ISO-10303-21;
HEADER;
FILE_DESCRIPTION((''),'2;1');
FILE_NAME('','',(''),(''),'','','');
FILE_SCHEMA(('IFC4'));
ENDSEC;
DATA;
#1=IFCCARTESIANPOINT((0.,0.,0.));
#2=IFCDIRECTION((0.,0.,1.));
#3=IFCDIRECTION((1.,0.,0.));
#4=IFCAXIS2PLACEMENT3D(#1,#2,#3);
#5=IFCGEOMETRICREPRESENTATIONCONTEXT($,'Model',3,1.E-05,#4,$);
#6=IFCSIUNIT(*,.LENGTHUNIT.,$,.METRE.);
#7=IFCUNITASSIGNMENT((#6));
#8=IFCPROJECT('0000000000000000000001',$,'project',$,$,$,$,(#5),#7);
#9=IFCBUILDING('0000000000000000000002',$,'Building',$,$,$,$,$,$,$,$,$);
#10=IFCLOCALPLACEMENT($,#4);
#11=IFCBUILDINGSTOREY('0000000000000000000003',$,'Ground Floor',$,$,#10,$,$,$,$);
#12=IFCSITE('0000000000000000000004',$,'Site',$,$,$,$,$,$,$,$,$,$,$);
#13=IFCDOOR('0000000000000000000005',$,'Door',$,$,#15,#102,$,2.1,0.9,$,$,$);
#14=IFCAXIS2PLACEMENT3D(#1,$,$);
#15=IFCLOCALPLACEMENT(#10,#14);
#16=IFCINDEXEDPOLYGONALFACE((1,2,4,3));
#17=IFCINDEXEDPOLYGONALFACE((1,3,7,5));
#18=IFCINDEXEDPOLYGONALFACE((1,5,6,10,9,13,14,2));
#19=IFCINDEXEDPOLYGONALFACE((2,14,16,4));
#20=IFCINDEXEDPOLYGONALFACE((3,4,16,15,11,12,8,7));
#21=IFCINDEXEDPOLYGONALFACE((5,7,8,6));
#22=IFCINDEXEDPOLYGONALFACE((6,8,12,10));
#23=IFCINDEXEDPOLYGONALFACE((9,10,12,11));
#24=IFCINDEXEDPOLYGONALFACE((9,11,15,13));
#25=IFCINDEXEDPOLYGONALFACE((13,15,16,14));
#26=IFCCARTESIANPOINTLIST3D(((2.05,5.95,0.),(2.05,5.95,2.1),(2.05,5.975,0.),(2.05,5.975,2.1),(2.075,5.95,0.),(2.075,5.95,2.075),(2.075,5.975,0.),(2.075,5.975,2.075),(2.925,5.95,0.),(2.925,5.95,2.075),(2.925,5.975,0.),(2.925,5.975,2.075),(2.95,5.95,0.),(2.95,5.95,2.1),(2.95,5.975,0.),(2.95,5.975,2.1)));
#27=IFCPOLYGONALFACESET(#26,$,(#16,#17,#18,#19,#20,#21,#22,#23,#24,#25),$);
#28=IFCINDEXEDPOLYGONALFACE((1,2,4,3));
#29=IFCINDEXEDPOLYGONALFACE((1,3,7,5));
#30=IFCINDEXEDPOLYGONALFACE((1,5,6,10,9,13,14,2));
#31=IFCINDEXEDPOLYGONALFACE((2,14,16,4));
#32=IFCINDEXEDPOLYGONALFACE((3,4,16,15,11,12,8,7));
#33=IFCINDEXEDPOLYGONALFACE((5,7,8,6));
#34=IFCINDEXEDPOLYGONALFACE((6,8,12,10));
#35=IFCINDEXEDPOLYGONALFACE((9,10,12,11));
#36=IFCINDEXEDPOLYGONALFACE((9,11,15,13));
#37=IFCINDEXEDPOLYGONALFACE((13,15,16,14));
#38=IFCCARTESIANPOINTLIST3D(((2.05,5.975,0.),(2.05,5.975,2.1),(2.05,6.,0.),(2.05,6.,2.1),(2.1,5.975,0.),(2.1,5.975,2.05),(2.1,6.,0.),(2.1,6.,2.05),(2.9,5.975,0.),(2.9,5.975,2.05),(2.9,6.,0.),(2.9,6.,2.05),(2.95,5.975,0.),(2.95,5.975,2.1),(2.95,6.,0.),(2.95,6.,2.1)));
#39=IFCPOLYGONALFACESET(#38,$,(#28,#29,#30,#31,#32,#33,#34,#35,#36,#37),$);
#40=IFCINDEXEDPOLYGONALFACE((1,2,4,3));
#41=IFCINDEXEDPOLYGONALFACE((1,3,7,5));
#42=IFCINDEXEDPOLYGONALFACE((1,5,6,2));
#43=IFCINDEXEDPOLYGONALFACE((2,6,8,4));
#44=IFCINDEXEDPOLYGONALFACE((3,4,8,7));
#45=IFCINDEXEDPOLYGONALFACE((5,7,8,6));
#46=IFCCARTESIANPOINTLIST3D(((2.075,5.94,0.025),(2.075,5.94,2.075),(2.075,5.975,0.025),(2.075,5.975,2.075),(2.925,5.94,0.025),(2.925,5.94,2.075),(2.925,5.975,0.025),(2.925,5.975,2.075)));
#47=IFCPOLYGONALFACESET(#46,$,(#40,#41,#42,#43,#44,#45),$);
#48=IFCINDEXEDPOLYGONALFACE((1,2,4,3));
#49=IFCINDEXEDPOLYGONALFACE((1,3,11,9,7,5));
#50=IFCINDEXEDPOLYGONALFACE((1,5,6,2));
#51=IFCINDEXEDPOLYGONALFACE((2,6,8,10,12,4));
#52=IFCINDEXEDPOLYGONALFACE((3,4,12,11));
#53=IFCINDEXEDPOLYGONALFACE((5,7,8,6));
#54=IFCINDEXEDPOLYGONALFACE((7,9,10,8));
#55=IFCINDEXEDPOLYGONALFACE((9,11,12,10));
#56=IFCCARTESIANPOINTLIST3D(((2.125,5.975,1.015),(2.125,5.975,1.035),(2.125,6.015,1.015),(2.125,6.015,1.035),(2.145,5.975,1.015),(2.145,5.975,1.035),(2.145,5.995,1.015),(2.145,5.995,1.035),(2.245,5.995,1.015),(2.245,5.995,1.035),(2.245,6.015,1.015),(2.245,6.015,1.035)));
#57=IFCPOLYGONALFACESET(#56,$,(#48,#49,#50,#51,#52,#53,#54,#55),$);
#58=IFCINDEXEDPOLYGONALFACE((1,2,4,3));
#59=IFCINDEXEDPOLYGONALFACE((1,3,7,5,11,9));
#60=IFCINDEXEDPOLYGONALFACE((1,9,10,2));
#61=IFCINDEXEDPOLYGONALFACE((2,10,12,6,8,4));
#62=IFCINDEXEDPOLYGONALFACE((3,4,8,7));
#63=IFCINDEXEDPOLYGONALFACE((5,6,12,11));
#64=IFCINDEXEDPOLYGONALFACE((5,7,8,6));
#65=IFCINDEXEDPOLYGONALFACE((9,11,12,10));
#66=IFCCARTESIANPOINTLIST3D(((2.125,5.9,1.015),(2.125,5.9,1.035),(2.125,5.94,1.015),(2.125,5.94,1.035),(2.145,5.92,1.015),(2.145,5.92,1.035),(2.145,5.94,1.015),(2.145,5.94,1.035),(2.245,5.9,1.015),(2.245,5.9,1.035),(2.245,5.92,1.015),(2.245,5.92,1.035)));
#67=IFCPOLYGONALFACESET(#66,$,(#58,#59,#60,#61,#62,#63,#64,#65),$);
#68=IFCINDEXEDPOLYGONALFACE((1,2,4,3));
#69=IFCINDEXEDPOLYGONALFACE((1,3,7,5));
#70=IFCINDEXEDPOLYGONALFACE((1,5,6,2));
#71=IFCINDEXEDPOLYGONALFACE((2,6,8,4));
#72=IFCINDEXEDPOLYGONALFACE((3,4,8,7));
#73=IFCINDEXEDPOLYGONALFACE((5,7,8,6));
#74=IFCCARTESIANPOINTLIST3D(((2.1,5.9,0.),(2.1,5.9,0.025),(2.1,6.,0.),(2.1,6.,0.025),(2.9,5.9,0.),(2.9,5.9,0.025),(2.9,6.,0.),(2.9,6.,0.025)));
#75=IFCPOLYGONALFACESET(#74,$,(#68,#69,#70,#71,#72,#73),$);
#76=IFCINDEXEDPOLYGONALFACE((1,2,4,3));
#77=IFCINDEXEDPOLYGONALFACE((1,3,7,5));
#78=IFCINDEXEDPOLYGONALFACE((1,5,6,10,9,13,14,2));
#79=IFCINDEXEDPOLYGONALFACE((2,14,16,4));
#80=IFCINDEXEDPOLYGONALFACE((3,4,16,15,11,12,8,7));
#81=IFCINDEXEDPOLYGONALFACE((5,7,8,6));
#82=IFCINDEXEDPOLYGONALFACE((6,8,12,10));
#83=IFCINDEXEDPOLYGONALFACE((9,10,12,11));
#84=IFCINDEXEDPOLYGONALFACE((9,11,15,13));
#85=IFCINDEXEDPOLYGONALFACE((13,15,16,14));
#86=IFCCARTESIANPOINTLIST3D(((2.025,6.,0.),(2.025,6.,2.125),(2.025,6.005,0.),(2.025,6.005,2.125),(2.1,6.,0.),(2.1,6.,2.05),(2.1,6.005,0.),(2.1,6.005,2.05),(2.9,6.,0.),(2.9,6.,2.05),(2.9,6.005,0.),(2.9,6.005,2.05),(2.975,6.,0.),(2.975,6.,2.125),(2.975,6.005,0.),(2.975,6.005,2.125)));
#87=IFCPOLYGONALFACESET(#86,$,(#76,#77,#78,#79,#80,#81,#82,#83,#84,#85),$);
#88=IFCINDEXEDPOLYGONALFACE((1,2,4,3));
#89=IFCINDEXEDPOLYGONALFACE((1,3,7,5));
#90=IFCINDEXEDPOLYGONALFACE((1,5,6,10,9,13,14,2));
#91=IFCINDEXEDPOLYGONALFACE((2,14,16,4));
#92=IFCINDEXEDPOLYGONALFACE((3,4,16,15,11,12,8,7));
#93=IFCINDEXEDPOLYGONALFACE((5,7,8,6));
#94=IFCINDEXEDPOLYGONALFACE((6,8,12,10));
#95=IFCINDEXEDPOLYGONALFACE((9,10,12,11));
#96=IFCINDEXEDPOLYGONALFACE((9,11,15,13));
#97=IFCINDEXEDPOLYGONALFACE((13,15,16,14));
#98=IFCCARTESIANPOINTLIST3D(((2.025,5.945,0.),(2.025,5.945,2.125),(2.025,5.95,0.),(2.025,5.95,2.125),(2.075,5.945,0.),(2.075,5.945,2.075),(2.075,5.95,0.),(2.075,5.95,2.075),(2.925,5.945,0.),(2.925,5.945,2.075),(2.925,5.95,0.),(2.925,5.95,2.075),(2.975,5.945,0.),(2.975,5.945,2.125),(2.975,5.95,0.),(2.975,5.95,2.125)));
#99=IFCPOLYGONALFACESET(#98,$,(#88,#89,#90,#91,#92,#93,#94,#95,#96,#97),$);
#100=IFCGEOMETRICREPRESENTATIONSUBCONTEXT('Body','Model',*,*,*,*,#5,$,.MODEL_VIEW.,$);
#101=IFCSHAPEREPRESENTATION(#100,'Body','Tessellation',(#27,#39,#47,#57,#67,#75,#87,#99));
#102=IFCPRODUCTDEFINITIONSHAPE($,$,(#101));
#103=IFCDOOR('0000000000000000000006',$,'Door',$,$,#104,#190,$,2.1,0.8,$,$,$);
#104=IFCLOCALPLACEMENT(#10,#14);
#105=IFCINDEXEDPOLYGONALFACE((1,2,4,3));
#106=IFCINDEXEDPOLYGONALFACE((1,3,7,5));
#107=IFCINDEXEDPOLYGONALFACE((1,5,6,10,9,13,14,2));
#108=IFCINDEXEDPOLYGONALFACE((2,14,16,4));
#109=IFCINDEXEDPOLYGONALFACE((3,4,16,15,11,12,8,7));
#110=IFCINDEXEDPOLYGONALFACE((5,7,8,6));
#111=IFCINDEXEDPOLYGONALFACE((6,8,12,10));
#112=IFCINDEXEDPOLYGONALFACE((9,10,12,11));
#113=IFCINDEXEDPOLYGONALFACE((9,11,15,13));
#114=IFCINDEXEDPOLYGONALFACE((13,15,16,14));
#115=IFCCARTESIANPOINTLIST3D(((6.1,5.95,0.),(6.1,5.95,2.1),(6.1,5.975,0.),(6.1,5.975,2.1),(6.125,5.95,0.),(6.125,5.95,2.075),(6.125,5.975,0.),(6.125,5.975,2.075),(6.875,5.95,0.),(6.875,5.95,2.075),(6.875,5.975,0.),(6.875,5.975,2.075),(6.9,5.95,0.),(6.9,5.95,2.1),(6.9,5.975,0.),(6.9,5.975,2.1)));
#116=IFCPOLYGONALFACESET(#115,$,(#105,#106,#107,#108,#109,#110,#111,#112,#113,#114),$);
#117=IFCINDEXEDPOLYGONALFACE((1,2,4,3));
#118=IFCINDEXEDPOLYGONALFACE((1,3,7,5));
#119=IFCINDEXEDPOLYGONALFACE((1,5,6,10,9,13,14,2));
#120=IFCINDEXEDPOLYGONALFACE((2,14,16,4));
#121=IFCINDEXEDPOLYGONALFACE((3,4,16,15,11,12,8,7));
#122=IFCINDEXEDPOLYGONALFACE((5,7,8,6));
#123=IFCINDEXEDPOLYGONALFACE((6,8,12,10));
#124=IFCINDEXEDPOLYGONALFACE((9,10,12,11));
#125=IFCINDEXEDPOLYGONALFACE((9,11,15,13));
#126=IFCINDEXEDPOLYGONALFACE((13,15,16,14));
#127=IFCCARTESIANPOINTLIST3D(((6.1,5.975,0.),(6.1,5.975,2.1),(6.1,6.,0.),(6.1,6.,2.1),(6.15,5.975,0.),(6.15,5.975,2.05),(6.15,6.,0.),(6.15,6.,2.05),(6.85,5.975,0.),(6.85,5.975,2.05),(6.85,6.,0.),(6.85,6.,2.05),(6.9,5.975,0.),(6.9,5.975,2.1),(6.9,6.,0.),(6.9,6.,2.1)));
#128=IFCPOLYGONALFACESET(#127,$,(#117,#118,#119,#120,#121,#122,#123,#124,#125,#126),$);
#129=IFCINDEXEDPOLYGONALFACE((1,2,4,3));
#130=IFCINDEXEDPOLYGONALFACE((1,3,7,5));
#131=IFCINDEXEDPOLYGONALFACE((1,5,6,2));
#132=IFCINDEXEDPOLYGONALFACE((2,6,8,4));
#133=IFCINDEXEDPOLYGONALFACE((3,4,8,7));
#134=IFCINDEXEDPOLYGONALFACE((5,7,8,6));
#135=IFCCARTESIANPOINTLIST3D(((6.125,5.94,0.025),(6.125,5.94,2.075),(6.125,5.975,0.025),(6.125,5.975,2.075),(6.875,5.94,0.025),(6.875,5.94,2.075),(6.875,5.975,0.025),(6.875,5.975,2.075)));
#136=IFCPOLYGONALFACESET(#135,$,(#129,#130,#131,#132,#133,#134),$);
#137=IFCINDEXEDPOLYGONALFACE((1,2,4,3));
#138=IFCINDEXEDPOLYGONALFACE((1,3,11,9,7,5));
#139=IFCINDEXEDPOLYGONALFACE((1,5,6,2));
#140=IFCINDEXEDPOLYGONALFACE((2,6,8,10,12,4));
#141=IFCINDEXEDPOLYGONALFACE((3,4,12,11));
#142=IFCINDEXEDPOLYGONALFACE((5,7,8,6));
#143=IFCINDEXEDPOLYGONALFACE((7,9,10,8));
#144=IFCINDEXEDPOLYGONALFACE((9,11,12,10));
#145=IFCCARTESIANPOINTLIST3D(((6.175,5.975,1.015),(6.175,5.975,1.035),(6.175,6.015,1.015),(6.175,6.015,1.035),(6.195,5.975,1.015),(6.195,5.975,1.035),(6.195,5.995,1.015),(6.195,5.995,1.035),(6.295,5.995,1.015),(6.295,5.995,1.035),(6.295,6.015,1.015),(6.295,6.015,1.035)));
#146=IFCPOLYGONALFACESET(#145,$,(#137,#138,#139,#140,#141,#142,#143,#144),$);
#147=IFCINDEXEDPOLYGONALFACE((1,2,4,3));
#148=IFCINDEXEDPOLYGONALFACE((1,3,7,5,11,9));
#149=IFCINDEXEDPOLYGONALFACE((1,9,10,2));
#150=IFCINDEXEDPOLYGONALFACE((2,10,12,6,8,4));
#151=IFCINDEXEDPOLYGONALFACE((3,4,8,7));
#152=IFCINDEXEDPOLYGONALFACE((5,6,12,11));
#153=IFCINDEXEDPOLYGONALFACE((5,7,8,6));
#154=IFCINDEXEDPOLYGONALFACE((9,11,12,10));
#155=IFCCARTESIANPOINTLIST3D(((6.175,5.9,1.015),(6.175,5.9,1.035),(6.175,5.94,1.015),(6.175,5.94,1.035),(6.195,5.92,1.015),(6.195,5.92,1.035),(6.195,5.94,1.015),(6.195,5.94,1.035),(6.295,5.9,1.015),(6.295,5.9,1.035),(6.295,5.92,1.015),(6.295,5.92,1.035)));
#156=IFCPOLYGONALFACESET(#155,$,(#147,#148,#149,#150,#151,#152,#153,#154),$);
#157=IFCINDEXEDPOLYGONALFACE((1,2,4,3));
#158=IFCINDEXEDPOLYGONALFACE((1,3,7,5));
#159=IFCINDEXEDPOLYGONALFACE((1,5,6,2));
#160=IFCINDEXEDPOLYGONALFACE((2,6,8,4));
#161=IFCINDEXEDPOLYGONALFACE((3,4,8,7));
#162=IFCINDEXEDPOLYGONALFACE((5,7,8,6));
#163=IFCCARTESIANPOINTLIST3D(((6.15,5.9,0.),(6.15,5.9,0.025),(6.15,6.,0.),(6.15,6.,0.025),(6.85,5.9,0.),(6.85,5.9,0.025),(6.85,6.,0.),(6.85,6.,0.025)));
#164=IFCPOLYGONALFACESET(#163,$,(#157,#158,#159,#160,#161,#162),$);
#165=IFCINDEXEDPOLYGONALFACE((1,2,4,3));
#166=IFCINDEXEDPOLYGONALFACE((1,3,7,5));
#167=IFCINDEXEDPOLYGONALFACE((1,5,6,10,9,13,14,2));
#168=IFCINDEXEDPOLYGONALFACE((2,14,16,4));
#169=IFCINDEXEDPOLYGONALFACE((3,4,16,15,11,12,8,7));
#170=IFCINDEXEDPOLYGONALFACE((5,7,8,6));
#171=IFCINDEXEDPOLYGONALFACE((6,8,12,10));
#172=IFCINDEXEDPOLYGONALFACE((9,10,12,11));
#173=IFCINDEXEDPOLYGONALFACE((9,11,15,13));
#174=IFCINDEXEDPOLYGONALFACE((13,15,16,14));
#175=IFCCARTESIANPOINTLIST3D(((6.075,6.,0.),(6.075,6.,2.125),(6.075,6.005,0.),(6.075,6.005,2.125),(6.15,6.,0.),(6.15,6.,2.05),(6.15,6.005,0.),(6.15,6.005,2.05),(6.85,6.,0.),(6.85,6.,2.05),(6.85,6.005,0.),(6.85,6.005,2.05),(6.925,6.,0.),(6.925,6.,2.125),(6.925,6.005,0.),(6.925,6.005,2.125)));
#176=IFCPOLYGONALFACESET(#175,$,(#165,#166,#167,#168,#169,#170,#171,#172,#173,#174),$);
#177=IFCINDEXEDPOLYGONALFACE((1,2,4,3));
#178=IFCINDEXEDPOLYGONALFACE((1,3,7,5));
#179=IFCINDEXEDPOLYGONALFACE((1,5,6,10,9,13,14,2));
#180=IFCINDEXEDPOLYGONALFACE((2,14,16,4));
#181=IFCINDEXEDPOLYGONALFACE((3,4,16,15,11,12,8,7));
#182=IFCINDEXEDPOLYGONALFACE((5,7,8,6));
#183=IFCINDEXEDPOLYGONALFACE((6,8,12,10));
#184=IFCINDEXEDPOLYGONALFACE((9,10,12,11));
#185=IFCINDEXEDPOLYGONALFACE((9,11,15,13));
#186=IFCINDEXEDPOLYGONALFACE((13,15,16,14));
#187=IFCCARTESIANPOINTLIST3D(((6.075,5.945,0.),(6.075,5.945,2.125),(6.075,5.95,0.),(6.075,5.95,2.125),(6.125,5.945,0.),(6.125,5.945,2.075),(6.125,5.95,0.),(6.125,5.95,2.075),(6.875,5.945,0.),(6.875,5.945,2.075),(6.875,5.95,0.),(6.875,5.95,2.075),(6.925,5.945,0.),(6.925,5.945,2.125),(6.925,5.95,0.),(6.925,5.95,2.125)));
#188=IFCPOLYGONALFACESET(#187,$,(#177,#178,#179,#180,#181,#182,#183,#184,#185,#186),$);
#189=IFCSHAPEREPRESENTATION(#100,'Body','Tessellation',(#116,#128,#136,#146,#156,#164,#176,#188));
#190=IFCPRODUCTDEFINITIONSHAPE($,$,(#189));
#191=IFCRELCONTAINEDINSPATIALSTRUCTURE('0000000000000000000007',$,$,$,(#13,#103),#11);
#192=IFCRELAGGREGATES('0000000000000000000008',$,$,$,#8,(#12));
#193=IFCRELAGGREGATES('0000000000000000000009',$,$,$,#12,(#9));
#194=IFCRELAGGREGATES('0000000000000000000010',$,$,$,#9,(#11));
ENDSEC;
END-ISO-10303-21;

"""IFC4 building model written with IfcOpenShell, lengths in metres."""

from ifc_helpers import new_model, si_unit, frame, origin_with_axes, place, context, subcontext, project, spatial, line, indexed_curve, outline, extrude, element, save


model = new_model("IFC4")

# Units and contexts
model_context = context("Model", 3, precision=1e-05, world=origin_with_axes())
body_context = subcontext(model_context, "Body", "Model", "MODEL_VIEW")
ifc_project = project(units=[si_unit("LENGTHUNIT", "METRE")], contexts=[model_context])

# Site, building, storey
site = spatial("IfcSite", under=ifc_project, Name="Site")
building = spatial("IfcBuilding", under=site, Name="Building")
storey_placement = place(None, origin_with_axes())
storey = spatial("IfcBuildingStorey", under=building, at=storey_placement, Name="Ground Floor")

# Doors
door_1_placement = place(storey_placement, frame((2.95, 6.0, 0.0), z_axis=(0.0, 0.0, 1.0), x_axis=(-1.0, 0.0, 0.0)))
element("IfcDoor", 1, at=door_1_placement, inside=storey, Name="Door", OverallHeight=2.1, OverallWidth=0.9, context=body_context, shape_type="SweptSolid", body=[
    extrude(outline(indexed_curve([(0.0, 0.0), (0.0, 2.1), (0.9, 2.1), (0.9, 0.0), (0.875, 0.0), (0.875, 2.075), (0.025, 2.075), (0.025, 0.0)], segments=[line(1, 2, 3, 4, 5, 6, 7, 8, 1)])), frame((0.0, 0.025, 0.0), z_axis=(0.0, -1.0, 0.0), x_axis=(1.0, 0.0, 0.0)), (0.0, 0.0, -1.0), 0.025),
    extrude(outline(indexed_curve([(0.0, 0.0), (0.0, 2.1), (0.9, 2.1), (0.9, 0.0), (0.85, 0.0), (0.85, 2.05), (0.05, 2.05), (0.05, 0.0)], segments=[line(1, 2, 3, 4, 5, 6, 7, 8, 1)])), frame((0.0, 0.0, 0.0), z_axis=(0.0, -1.0, 0.0), x_axis=(1.0, 0.0, 0.0)), (0.0, 0.0, -1.0), 0.025),
    extrude(outline(indexed_curve([(0.0, 0.0), (0.85, 0.0), (0.85, 0.035), (0.0, 0.035)], segments=[line(1, 2, 3, 4, 1)])), frame((0.025, 0.025, 0.025), z_axis=(0.0, 0.0, 1.0), x_axis=(1.0, 0.0, 0.0)), (0.0, 0.0, 1.0), 2.05),
    extrude(outline(indexed_curve([(0.0, 0.0), (0.0, -0.04), (-0.12, -0.04), (-0.12, -0.02), (-0.02, -0.02), (-0.02, 0.0)], segments=[line(1, 2, 3, 4, 5, 6, 1)])), frame((0.825, 0.025, 1.015), z_axis=(0.0, 0.0, 1.0), x_axis=(1.0, 0.0, 0.0)), (0.0, 0.0, 1.0), 0.02),
    extrude(outline(indexed_curve([(0.0, 0.0), (0.0, 0.04), (-0.12, 0.04), (-0.12, 0.02), (-0.02, 0.02), (-0.02, 0.0)], segments=[line(1, 2, 3, 4, 5, 6, 1)])), frame((0.825, 0.06, 1.015), z_axis=(0.0, 0.0, 1.0), x_axis=(1.0, 0.0, 0.0)), (0.0, 0.0, 1.0), 0.02),
    extrude(outline(indexed_curve([(0.0, 0.0), (0.8, 0.0), (0.8, 0.1), (0.0, 0.1)], segments=[line(1, 2, 3, 4, 1)])), frame((0.05, 0.0, 0.0), z_axis=(0.0, 0.0, 1.0), x_axis=(1.0, 0.0, 0.0)), (0.0, 0.0, 1.0), 0.025),
    extrude(outline(indexed_curve([(0.0, 0.0), (0.0, 2.125), (0.95, 2.125), (0.95, 0.0), (0.875, 0.0), (0.875, 2.05), (0.075, 2.05), (0.075, 0.0)], segments=[line(1, 2, 3, 4, 5, 6, 7, 8, 1)])), frame((-0.025, -0.005, 0.0), z_axis=(0.0, -1.0, 0.0), x_axis=(1.0, 0.0, 0.0)), (0.0, 0.0, -1.0), 0.005),
    extrude(outline(indexed_curve([(0.0, 0.0), (0.0, 2.125), (0.95, 2.125), (0.95, 0.0), (0.9, 0.0), (0.9, 2.075), (0.05, 2.075), (0.05, 0.0)], segments=[line(1, 2, 3, 4, 5, 6, 7, 8, 1)])), frame((-0.025, 0.05, 0.0), z_axis=(0.0, -1.0, 0.0), x_axis=(1.0, 0.0, 0.0)), (0.0, 0.0, -1.0), 0.005),
])
door_2_placement = place(storey_placement, frame((6.9, 6.0, 0.0), z_axis=(0.0, 0.0, 1.0), x_axis=(-1.0, 0.0, 0.0)))
element("IfcDoor", 2, at=door_2_placement, inside=storey, Name="Door", OverallHeight=2.1, OverallWidth=0.8, context=body_context, shape_type="SweptSolid", body=[
    extrude(outline(indexed_curve([(0.0, 0.0), (0.0, 2.1), (0.8, 2.1), (0.8, 0.0), (0.775, 0.0), (0.775, 2.075), (0.025, 2.075), (0.025, 0.0)], segments=[line(1, 2, 3, 4, 5, 6, 7, 8, 1)])), frame((0.0, 0.025, 0.0), z_axis=(0.0, -1.0, 0.0), x_axis=(1.0, 0.0, 0.0)), (0.0, 0.0, -1.0), 0.025),
    extrude(outline(indexed_curve([(0.0, 0.0), (0.0, 2.1), (0.8, 2.1), (0.8, 0.0), (0.75, 0.0), (0.75, 2.05), (0.05, 2.05), (0.05, 0.0)], segments=[line(1, 2, 3, 4, 5, 6, 7, 8, 1)])), frame((0.0, 0.0, 0.0), z_axis=(0.0, -1.0, 0.0), x_axis=(1.0, 0.0, 0.0)), (0.0, 0.0, -1.0), 0.025),
    extrude(outline(indexed_curve([(0.0, 0.0), (0.75, 0.0), (0.75, 0.035), (0.0, 0.035)], segments=[line(1, 2, 3, 4, 1)])), frame((0.025, 0.025, 0.025), z_axis=(0.0, 0.0, 1.0), x_axis=(1.0, 0.0, 0.0)), (0.0, 0.0, 1.0), 2.05),
    extrude(outline(indexed_curve([(0.0, 0.0), (0.0, -0.04), (-0.12, -0.04), (-0.12, -0.02), (-0.02, -0.02), (-0.02, 0.0)], segments=[line(1, 2, 3, 4, 5, 6, 1)])), frame((0.725, 0.025, 1.015), z_axis=(0.0, 0.0, 1.0), x_axis=(1.0, 0.0, 0.0)), (0.0, 0.0, 1.0), 0.02),
    extrude(outline(indexed_curve([(0.0, 0.0), (0.0, 0.04), (-0.12, 0.04), (-0.12, 0.02), (-0.02, 0.02), (-0.02, 0.0)], segments=[line(1, 2, 3, 4, 5, 6, 1)])), frame((0.725, 0.06, 1.015), z_axis=(0.0, 0.0, 1.0), x_axis=(1.0, 0.0, 0.0)), (0.0, 0.0, 1.0), 0.02),
    extrude(outline(indexed_curve([(0.0, 0.0), (0.7, 0.0), (0.7, 0.1), (0.0, 0.1)], segments=[line(1, 2, 3, 4, 1)])), frame((0.05, 0.0, 0.0), z_axis=(0.0, 0.0, 1.0), x_axis=(1.0, 0.0, 0.0)), (0.0, 0.0, 1.0), 0.025),
    extrude(outline(indexed_curve([(0.0, 0.0), (0.0, 2.125), (0.85, 2.125), (0.85, 0.0), (0.775, 0.0), (0.775, 2.05), (0.075, 2.05), (0.075, 0.0)], segments=[line(1, 2, 3, 4, 5, 6, 7, 8, 1)])), frame((-0.025, -0.005, 0.0), z_axis=(0.0, -1.0, 0.0), x_axis=(1.0, 0.0, 0.0)), (0.0, 0.0, -1.0), 0.005),
    extrude(outline(indexed_curve([(0.0, 0.0), (0.0, 2.125), (0.85, 2.125), (0.85, 0.0), (0.8, 0.0), (0.8, 2.075), (0.05, 2.075), (0.05, 0.0)], segments=[line(1, 2, 3, 4, 5, 6, 7, 8, 1)])), frame((-0.025, 0.05, 0.0), z_axis=(0.0, -1.0, 0.0), x_axis=(1.0, 0.0, 0.0)), (0.0, 0.0, -1.0), 0.005),
])

save(model, "model.ifc")
